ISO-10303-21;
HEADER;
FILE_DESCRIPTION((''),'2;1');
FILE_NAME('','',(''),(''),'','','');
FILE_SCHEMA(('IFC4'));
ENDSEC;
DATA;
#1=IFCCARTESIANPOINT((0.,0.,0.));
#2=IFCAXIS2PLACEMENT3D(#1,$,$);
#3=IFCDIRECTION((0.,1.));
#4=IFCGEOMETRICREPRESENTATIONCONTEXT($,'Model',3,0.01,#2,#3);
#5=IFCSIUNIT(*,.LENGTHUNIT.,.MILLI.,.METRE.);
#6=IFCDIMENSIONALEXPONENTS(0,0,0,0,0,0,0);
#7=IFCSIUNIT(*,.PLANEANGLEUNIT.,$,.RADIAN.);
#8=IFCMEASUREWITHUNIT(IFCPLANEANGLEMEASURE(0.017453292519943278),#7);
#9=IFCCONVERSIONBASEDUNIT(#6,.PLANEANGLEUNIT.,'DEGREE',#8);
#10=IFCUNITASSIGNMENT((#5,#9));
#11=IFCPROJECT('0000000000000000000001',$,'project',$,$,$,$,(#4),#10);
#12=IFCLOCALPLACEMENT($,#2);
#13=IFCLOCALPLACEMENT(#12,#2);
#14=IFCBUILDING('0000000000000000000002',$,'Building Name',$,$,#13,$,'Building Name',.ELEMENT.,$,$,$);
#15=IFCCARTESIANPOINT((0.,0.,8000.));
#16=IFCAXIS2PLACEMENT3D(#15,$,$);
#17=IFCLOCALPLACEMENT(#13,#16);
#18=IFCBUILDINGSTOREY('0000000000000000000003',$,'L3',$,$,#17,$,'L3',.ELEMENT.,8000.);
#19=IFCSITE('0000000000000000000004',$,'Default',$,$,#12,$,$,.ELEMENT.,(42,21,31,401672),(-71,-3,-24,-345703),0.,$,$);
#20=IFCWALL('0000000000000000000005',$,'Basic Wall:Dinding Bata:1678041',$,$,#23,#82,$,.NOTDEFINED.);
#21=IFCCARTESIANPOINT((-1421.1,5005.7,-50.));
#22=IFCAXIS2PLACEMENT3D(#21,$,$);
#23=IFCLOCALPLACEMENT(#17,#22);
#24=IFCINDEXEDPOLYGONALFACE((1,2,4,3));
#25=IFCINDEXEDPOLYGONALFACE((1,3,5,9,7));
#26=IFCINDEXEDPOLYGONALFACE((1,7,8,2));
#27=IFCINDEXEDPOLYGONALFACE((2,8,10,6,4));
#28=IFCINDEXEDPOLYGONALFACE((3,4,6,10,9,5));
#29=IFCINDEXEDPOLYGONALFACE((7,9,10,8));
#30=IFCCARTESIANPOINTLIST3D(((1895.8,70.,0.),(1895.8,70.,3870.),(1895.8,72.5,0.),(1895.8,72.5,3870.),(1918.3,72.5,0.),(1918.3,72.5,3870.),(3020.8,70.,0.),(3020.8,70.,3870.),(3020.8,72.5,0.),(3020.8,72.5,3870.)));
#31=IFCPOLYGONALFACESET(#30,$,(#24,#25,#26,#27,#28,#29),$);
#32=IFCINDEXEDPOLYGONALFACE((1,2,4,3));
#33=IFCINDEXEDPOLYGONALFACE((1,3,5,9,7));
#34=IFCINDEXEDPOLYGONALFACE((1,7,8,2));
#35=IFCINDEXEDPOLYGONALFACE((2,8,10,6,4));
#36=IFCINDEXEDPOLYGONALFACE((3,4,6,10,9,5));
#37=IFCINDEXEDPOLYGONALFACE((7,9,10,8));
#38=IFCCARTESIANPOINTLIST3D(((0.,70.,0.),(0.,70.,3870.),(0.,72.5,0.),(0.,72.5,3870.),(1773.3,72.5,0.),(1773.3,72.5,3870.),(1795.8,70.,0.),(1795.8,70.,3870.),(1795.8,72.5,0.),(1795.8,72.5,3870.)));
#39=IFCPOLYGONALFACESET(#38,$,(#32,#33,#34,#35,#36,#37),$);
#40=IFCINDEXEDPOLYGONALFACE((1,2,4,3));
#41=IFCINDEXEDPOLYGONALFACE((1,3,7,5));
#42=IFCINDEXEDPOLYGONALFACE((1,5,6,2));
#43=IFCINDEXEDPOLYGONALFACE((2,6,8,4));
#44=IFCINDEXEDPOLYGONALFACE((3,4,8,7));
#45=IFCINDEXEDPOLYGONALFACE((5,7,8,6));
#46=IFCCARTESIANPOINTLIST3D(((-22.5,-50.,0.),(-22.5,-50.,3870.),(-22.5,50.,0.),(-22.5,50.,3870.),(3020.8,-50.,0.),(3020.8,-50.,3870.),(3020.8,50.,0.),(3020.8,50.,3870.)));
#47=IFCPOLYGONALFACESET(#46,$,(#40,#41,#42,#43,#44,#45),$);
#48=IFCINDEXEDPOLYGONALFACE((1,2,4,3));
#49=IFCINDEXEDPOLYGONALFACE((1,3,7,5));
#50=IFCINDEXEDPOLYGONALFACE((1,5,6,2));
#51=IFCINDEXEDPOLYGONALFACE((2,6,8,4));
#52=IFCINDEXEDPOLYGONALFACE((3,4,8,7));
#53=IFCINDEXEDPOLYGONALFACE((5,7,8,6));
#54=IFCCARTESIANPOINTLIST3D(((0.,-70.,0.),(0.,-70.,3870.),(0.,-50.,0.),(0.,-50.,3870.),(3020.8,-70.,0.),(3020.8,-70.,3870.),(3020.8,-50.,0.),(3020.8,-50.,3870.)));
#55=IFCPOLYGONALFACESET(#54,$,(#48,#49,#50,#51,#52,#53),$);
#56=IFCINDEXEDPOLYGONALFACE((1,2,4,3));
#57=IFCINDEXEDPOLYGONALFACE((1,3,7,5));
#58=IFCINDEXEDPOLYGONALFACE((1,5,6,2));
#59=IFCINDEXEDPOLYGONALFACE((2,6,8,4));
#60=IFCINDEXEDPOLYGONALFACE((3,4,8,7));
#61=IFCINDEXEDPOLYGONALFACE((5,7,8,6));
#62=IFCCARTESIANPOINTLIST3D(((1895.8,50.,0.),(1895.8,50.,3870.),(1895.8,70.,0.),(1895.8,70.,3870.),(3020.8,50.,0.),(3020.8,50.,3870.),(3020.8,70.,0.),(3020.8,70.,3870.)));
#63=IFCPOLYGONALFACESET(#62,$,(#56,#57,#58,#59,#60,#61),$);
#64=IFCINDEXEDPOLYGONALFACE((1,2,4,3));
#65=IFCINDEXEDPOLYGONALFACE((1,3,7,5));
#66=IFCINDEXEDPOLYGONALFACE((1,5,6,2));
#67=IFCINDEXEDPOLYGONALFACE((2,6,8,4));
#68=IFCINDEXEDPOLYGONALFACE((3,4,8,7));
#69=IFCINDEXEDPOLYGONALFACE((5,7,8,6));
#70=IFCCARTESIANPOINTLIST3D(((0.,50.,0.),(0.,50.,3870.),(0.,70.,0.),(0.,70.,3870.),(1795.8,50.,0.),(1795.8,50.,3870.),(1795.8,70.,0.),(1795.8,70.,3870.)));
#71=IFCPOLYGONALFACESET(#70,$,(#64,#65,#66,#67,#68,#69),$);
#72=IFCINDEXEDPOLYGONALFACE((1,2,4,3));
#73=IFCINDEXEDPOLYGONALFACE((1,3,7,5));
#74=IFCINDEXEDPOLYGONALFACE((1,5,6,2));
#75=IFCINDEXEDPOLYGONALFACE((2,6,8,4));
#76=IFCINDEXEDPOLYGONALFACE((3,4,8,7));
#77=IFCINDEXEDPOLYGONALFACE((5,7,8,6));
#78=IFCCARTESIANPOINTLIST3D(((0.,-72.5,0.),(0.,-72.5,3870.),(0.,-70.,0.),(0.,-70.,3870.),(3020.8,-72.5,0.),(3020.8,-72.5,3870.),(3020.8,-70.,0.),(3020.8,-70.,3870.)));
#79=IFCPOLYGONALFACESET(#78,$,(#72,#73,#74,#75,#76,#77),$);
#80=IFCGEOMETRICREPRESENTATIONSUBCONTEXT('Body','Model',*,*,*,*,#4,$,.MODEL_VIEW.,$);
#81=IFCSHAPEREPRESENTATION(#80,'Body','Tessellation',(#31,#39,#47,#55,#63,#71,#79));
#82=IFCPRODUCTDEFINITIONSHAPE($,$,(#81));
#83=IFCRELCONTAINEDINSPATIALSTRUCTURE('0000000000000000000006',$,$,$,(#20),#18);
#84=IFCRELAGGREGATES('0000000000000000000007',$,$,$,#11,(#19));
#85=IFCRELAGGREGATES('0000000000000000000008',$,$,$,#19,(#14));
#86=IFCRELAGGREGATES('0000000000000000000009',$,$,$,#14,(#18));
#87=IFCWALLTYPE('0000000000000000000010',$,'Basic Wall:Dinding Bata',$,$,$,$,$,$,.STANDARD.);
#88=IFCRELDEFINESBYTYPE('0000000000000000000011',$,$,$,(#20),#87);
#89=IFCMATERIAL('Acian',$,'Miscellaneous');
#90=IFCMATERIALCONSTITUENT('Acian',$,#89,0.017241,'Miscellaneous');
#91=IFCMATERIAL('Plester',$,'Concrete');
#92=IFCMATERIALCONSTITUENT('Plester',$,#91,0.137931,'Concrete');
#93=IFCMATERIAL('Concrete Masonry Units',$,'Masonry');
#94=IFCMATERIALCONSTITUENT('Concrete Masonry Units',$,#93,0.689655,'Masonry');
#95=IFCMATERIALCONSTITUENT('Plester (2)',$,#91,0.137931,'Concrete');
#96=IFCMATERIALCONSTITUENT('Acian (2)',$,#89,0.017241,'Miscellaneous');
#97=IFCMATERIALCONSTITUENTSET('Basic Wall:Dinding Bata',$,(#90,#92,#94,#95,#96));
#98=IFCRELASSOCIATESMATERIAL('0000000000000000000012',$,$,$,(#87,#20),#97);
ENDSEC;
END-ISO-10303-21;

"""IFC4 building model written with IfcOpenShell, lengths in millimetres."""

from ifc_helpers import new_model, entity, si_unit, converted_unit, direction, frame, origin, place, context, subcontext, project, spatial, indexed_curve, outline, extrude, material, constituent, constituent_set, type_object, element, save


model = new_model("IFC4")

# Units and contexts
model_context = context("Model", 3, precision=0.01, world=origin(), true_north=direction((0.0, 1.0)))
body_context = subcontext(model_context, "Body", "Model", "MODEL_VIEW")
ifc_project = project(units=[si_unit("LENGTHUNIT", "METRE", prefix="MILLI"), converted_unit("PLANEANGLEUNIT", "DEGREE", entity("IfcPlaneAngleMeasure", 0.017453292519943278), si_unit("PLANEANGLEUNIT", "RADIAN"), dimensions=[0, 0, 0, 0, 0, 0, 0])], contexts=[model_context])

# Site, building, storey
site_placement = place(None, origin())
site = spatial("IfcSite", under=ifc_project, at=site_placement, Name="Default", CompositionType="ELEMENT", RefLatitude=(42, 21, 31, 401672), RefLongitude=(-71, -3, -24, -345703), RefElevation=0.0)
building_placement = place(site_placement, origin())
building = spatial("IfcBuilding", under=site, at=building_placement, Name="Building Name", LongName="Building Name", CompositionType="ELEMENT")
storey_placement = place(building_placement, frame((0.0, 0.0, 8000.0)))
storey = spatial("IfcBuildingStorey", under=building, at=storey_placement, Name="L3", LongName="L3", CompositionType="ELEMENT", Elevation=8000.0)

# Wall
ifc_material_1 = material(Name="Acian", Category="Miscellaneous")
ifc_constituent_1 = constituent(ifc_material_1, Name="Acian", Category="Miscellaneous", fraction=0.017241)
ifc_material_2 = material(Name="Plester", Category="Concrete")
ifc_constituent_2 = constituent(ifc_material_2, Name="Plester", Category="Concrete", fraction=0.137931)
ifc_material_3 = material(Name="Concrete Masonry Units", Category="Masonry")
ifc_constituent_3 = constituent(ifc_material_3, Name="Concrete Masonry Units", Category="Masonry", fraction=0.689655)
ifc_constituent_4 = constituent(ifc_material_2, Name="Plester (2)", Category="Concrete", fraction=0.137931)
ifc_constituent_5 = constituent(ifc_material_1, Name="Acian (2)", Category="Miscellaneous", fraction=0.017241)
ifc_constituent_set = constituent_set(constituents=[ifc_constituent_1, ifc_constituent_2, ifc_constituent_3, ifc_constituent_4, ifc_constituent_5], Name="Basic Wall:Dinding Bata")
wall_type = type_object("IfcWallType", Name="Basic Wall:Dinding Bata", PredefinedType="STANDARD", material=ifc_constituent_set)
wall_1_placement = place(storey_placement, frame((-1421.1, 5005.7, -50.0)))
element("IfcWall", 1, at=wall_1_placement, inside=storey, type_object=wall_type, material=ifc_constituent_set, Name="Basic Wall:Dinding Bata:1678041", PredefinedType="NOTDEFINED", context=body_context, shape_type="SweptSolid", body=[
    extrude(outline(indexed_curve([(432.0, -1.0), (454.5, -1.0), (454.5, 1.5), (-670.5, 1.5), (-670.5, -1.0), (432.0, -1.0)], self_intersect=False)), frame((2350.3, 71.5, 0.0), z_axis=(0.0, 0.0, 1.0), x_axis=(-1.0, 0.0, 0.0)), (0.0, 0.0, 1.0), 3870.0),
    extrude(outline(indexed_curve([(-1073.0, -1.5), (722.8, -1.5), (722.8, 1.0), (700.3, 1.0), (-1073.0, 1.0), (-1073.0, -1.5)], self_intersect=False)), frame((1073.0, 71.5, 0.0)), (0.0, 0.0, 1.0), 3870.0),
    extrude(outline(indexed_curve([(-1521.6, -50.0), (1521.6, -50.0), (1521.6, 50.0), (-1521.6, 50.0), (-1521.6, -50.0)], self_intersect=False)), frame((1499.1, 0.0, 0.0)), (0.0, 0.0, 1.0), 3870.0),
    extrude(outline(indexed_curve([(-1510.4, -10.0), (1510.4, -10.0), (1510.4, 10.0), (-1510.4, 10.0), (-1510.4, -10.0)], self_intersect=False)), frame((1510.4, -60.0, 0.0)), (0.0, 0.0, 1.0), 3870.0),
    extrude(outline(indexed_curve([(-562.5, -10.0), (562.5, -10.0), (562.5, 10.0), (-562.5, 10.0), (-562.5, -10.0)], self_intersect=False)), frame((2458.3, 60.0, 0.0), z_axis=(0.0, 0.0, 1.0), x_axis=(-1.0, 0.0, 0.0)), (0.0, 0.0, 1.0), 3870.0),
    extrude(outline(indexed_curve([(-897.9, -10.0), (897.9, -10.0), (897.9, 10.0), (-897.9, 10.0), (-897.9, -10.0)], self_intersect=False)), frame((897.9, 60.0, 0.0)), (0.0, 0.0, 1.0), 3870.0),
    extrude(outline(indexed_curve([(-1.3, -1510.4), (1.2, -1510.4), (1.3, 1510.4), (-1.2, 1510.4), (-1.3, -1510.4)], self_intersect=False)), frame((1510.4, -71.3, 0.0), z_axis=(0.0, 0.0, 1.0), x_axis=(0.0, 1.0, 0.0)), (0.0, 0.0, 1.0), 3870.0),
])

save(model, "model.ifc")
